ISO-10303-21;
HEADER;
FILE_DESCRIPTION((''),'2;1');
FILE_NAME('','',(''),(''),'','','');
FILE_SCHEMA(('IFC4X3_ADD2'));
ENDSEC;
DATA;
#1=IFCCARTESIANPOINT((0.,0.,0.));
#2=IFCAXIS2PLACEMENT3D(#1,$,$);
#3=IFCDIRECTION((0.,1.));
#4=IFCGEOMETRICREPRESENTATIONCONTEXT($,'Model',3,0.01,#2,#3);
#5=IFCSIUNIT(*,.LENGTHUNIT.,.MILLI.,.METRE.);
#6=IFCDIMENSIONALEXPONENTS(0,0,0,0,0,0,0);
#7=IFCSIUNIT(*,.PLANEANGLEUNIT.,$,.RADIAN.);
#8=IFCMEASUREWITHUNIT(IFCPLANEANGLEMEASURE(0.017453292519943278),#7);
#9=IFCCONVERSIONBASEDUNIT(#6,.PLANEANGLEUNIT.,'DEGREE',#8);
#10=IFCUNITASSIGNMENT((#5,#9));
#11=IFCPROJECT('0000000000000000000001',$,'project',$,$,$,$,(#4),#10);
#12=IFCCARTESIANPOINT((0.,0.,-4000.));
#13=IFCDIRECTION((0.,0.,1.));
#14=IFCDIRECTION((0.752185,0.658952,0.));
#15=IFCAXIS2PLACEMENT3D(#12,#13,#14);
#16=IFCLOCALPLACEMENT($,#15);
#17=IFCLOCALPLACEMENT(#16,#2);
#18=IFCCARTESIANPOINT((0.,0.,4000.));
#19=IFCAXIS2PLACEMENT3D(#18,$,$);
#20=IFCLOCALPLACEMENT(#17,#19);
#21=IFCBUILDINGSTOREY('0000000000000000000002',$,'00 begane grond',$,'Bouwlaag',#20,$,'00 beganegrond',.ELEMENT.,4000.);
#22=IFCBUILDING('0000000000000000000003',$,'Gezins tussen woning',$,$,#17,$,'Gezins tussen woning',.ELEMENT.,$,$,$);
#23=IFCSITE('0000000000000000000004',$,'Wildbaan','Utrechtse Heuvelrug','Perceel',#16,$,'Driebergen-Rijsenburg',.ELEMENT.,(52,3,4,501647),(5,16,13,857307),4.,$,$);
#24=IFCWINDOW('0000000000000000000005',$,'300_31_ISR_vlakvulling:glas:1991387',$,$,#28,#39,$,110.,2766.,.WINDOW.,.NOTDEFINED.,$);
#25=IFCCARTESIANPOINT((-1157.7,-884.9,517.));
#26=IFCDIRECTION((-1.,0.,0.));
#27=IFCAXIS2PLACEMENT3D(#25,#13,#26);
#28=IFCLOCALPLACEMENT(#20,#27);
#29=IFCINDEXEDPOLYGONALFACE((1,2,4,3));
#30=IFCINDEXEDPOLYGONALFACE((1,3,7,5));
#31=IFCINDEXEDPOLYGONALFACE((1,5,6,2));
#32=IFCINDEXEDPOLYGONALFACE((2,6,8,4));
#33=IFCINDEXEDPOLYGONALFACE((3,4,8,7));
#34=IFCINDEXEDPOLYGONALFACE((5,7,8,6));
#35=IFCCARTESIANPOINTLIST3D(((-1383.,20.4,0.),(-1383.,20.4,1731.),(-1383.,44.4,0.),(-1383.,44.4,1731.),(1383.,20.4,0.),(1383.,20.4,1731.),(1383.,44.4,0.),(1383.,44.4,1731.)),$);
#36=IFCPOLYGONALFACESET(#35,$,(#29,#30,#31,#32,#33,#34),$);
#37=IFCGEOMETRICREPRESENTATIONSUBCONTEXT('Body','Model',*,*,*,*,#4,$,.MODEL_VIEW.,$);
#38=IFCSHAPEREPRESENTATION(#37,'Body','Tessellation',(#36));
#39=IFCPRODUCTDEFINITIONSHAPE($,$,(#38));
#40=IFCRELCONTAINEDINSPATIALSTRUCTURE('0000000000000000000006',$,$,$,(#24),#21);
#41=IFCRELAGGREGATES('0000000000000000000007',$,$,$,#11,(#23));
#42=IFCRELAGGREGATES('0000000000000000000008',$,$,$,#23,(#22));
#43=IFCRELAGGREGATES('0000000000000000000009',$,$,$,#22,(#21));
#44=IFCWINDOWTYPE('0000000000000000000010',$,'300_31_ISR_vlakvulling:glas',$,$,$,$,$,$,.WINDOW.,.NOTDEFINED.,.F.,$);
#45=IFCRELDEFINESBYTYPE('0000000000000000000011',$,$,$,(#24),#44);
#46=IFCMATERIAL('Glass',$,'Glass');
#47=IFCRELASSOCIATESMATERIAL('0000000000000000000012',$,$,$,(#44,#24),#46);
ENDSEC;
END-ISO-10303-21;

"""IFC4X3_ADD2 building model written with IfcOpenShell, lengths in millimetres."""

from ifc_helpers import new_model, entity, si_unit, converted_unit, direction, frame, origin, origin_2d_with_axis, place, context, subcontext, project, spatial, rectangle, extrude, source, transform, mapped, material, type_object, type_shapes, element, save


model = new_model("IFC4X3_ADD2")

# Units and contexts
model_context = context("Model", 3, precision=0.01, world=origin(), true_north=direction((0.0, 1.0)))
body_context = subcontext(model_context, "Body", "Model", "MODEL_VIEW")
ifc_project = project(units=[si_unit("LENGTHUNIT", "METRE", prefix="MILLI"), converted_unit("PLANEANGLEUNIT", "DEGREE", entity("IfcPlaneAngleMeasure", 0.017453292519943278), si_unit("PLANEANGLEUNIT", "RADIAN"), dimensions=[0, 0, 0, 0, 0, 0, 0])], contexts=[model_context])

# Site, building, storey
site_placement = place(None, frame((0.0, 0.0, -4000.0), z_axis=(0.0, 0.0, 1.0), x_axis=(0.752185, 0.658952, 0.0)))
site = spatial("IfcSite", under=ifc_project, at=site_placement, Name="Wildbaan", Description="Utrechtse Heuvelrug", ObjectType="Perceel", LongName="Driebergen-Rijsenburg", CompositionType="ELEMENT", RefLatitude=(52, 3, 4, 501647), RefLongitude=(5, 16, 13, 857307), RefElevation=4.0)
building_placement = place(site_placement, origin())
building = spatial("IfcBuilding", under=site, at=building_placement, Name="Gezins tussen woning", LongName="Gezins tussen woning", CompositionType="ELEMENT")
storey_placement = place(building_placement, frame((0.0, 0.0, 4000.0)))
storey = spatial("IfcBuildingStorey", under=building, at=storey_placement, Name="00 begane grond", ObjectType="Bouwlaag", LongName="00 beganegrond", CompositionType="ELEMENT", Elevation=4000.0)

# Window
ifc_material_1 = material(Name="Glass", Category="Glass")
window_type_1 = type_object("IfcWindowType", Name="300_31_ISR_vlakvulling:glas", ParameterTakesPrecedence=False, PartitioningType="NOTDEFINED", PredefinedType="WINDOW", material=ifc_material_1)
shared_shape_1 = source(origin(), body_context, "Body", "SweptSolid", [
    extrude(rectangle(XDim=2766.0, YDim=24.0, at=origin_2d_with_axis()), frame((0.0, 32.4, 0.0)), (0.0, 0.0, 1.0), 1731.0),
])
type_shapes(window_type_1, [shared_shape_1])
window_1_placement = place(storey_placement, frame((-1157.7, -884.9, 517.0), z_axis=(0.0, 0.0, 1.0), x_axis=(-1.0, 0.0, 0.0)))
element("IfcWindow", 1, at=window_1_placement, inside=storey, type_object=window_type_1, material=ifc_material_1, Name="300_31_ISR_vlakvulling:glas:1991387", OverallHeight=110.0, OverallWidth=2766.0, PartitioningType="NOTDEFINED", PredefinedType="WINDOW", context=body_context, shape_type="MappedRepresentation", body=[
    mapped(shared_shape_1, transform((0.0, 0.0, 0.0), scale=1.0)),
])

save(model, "model.ifc")
